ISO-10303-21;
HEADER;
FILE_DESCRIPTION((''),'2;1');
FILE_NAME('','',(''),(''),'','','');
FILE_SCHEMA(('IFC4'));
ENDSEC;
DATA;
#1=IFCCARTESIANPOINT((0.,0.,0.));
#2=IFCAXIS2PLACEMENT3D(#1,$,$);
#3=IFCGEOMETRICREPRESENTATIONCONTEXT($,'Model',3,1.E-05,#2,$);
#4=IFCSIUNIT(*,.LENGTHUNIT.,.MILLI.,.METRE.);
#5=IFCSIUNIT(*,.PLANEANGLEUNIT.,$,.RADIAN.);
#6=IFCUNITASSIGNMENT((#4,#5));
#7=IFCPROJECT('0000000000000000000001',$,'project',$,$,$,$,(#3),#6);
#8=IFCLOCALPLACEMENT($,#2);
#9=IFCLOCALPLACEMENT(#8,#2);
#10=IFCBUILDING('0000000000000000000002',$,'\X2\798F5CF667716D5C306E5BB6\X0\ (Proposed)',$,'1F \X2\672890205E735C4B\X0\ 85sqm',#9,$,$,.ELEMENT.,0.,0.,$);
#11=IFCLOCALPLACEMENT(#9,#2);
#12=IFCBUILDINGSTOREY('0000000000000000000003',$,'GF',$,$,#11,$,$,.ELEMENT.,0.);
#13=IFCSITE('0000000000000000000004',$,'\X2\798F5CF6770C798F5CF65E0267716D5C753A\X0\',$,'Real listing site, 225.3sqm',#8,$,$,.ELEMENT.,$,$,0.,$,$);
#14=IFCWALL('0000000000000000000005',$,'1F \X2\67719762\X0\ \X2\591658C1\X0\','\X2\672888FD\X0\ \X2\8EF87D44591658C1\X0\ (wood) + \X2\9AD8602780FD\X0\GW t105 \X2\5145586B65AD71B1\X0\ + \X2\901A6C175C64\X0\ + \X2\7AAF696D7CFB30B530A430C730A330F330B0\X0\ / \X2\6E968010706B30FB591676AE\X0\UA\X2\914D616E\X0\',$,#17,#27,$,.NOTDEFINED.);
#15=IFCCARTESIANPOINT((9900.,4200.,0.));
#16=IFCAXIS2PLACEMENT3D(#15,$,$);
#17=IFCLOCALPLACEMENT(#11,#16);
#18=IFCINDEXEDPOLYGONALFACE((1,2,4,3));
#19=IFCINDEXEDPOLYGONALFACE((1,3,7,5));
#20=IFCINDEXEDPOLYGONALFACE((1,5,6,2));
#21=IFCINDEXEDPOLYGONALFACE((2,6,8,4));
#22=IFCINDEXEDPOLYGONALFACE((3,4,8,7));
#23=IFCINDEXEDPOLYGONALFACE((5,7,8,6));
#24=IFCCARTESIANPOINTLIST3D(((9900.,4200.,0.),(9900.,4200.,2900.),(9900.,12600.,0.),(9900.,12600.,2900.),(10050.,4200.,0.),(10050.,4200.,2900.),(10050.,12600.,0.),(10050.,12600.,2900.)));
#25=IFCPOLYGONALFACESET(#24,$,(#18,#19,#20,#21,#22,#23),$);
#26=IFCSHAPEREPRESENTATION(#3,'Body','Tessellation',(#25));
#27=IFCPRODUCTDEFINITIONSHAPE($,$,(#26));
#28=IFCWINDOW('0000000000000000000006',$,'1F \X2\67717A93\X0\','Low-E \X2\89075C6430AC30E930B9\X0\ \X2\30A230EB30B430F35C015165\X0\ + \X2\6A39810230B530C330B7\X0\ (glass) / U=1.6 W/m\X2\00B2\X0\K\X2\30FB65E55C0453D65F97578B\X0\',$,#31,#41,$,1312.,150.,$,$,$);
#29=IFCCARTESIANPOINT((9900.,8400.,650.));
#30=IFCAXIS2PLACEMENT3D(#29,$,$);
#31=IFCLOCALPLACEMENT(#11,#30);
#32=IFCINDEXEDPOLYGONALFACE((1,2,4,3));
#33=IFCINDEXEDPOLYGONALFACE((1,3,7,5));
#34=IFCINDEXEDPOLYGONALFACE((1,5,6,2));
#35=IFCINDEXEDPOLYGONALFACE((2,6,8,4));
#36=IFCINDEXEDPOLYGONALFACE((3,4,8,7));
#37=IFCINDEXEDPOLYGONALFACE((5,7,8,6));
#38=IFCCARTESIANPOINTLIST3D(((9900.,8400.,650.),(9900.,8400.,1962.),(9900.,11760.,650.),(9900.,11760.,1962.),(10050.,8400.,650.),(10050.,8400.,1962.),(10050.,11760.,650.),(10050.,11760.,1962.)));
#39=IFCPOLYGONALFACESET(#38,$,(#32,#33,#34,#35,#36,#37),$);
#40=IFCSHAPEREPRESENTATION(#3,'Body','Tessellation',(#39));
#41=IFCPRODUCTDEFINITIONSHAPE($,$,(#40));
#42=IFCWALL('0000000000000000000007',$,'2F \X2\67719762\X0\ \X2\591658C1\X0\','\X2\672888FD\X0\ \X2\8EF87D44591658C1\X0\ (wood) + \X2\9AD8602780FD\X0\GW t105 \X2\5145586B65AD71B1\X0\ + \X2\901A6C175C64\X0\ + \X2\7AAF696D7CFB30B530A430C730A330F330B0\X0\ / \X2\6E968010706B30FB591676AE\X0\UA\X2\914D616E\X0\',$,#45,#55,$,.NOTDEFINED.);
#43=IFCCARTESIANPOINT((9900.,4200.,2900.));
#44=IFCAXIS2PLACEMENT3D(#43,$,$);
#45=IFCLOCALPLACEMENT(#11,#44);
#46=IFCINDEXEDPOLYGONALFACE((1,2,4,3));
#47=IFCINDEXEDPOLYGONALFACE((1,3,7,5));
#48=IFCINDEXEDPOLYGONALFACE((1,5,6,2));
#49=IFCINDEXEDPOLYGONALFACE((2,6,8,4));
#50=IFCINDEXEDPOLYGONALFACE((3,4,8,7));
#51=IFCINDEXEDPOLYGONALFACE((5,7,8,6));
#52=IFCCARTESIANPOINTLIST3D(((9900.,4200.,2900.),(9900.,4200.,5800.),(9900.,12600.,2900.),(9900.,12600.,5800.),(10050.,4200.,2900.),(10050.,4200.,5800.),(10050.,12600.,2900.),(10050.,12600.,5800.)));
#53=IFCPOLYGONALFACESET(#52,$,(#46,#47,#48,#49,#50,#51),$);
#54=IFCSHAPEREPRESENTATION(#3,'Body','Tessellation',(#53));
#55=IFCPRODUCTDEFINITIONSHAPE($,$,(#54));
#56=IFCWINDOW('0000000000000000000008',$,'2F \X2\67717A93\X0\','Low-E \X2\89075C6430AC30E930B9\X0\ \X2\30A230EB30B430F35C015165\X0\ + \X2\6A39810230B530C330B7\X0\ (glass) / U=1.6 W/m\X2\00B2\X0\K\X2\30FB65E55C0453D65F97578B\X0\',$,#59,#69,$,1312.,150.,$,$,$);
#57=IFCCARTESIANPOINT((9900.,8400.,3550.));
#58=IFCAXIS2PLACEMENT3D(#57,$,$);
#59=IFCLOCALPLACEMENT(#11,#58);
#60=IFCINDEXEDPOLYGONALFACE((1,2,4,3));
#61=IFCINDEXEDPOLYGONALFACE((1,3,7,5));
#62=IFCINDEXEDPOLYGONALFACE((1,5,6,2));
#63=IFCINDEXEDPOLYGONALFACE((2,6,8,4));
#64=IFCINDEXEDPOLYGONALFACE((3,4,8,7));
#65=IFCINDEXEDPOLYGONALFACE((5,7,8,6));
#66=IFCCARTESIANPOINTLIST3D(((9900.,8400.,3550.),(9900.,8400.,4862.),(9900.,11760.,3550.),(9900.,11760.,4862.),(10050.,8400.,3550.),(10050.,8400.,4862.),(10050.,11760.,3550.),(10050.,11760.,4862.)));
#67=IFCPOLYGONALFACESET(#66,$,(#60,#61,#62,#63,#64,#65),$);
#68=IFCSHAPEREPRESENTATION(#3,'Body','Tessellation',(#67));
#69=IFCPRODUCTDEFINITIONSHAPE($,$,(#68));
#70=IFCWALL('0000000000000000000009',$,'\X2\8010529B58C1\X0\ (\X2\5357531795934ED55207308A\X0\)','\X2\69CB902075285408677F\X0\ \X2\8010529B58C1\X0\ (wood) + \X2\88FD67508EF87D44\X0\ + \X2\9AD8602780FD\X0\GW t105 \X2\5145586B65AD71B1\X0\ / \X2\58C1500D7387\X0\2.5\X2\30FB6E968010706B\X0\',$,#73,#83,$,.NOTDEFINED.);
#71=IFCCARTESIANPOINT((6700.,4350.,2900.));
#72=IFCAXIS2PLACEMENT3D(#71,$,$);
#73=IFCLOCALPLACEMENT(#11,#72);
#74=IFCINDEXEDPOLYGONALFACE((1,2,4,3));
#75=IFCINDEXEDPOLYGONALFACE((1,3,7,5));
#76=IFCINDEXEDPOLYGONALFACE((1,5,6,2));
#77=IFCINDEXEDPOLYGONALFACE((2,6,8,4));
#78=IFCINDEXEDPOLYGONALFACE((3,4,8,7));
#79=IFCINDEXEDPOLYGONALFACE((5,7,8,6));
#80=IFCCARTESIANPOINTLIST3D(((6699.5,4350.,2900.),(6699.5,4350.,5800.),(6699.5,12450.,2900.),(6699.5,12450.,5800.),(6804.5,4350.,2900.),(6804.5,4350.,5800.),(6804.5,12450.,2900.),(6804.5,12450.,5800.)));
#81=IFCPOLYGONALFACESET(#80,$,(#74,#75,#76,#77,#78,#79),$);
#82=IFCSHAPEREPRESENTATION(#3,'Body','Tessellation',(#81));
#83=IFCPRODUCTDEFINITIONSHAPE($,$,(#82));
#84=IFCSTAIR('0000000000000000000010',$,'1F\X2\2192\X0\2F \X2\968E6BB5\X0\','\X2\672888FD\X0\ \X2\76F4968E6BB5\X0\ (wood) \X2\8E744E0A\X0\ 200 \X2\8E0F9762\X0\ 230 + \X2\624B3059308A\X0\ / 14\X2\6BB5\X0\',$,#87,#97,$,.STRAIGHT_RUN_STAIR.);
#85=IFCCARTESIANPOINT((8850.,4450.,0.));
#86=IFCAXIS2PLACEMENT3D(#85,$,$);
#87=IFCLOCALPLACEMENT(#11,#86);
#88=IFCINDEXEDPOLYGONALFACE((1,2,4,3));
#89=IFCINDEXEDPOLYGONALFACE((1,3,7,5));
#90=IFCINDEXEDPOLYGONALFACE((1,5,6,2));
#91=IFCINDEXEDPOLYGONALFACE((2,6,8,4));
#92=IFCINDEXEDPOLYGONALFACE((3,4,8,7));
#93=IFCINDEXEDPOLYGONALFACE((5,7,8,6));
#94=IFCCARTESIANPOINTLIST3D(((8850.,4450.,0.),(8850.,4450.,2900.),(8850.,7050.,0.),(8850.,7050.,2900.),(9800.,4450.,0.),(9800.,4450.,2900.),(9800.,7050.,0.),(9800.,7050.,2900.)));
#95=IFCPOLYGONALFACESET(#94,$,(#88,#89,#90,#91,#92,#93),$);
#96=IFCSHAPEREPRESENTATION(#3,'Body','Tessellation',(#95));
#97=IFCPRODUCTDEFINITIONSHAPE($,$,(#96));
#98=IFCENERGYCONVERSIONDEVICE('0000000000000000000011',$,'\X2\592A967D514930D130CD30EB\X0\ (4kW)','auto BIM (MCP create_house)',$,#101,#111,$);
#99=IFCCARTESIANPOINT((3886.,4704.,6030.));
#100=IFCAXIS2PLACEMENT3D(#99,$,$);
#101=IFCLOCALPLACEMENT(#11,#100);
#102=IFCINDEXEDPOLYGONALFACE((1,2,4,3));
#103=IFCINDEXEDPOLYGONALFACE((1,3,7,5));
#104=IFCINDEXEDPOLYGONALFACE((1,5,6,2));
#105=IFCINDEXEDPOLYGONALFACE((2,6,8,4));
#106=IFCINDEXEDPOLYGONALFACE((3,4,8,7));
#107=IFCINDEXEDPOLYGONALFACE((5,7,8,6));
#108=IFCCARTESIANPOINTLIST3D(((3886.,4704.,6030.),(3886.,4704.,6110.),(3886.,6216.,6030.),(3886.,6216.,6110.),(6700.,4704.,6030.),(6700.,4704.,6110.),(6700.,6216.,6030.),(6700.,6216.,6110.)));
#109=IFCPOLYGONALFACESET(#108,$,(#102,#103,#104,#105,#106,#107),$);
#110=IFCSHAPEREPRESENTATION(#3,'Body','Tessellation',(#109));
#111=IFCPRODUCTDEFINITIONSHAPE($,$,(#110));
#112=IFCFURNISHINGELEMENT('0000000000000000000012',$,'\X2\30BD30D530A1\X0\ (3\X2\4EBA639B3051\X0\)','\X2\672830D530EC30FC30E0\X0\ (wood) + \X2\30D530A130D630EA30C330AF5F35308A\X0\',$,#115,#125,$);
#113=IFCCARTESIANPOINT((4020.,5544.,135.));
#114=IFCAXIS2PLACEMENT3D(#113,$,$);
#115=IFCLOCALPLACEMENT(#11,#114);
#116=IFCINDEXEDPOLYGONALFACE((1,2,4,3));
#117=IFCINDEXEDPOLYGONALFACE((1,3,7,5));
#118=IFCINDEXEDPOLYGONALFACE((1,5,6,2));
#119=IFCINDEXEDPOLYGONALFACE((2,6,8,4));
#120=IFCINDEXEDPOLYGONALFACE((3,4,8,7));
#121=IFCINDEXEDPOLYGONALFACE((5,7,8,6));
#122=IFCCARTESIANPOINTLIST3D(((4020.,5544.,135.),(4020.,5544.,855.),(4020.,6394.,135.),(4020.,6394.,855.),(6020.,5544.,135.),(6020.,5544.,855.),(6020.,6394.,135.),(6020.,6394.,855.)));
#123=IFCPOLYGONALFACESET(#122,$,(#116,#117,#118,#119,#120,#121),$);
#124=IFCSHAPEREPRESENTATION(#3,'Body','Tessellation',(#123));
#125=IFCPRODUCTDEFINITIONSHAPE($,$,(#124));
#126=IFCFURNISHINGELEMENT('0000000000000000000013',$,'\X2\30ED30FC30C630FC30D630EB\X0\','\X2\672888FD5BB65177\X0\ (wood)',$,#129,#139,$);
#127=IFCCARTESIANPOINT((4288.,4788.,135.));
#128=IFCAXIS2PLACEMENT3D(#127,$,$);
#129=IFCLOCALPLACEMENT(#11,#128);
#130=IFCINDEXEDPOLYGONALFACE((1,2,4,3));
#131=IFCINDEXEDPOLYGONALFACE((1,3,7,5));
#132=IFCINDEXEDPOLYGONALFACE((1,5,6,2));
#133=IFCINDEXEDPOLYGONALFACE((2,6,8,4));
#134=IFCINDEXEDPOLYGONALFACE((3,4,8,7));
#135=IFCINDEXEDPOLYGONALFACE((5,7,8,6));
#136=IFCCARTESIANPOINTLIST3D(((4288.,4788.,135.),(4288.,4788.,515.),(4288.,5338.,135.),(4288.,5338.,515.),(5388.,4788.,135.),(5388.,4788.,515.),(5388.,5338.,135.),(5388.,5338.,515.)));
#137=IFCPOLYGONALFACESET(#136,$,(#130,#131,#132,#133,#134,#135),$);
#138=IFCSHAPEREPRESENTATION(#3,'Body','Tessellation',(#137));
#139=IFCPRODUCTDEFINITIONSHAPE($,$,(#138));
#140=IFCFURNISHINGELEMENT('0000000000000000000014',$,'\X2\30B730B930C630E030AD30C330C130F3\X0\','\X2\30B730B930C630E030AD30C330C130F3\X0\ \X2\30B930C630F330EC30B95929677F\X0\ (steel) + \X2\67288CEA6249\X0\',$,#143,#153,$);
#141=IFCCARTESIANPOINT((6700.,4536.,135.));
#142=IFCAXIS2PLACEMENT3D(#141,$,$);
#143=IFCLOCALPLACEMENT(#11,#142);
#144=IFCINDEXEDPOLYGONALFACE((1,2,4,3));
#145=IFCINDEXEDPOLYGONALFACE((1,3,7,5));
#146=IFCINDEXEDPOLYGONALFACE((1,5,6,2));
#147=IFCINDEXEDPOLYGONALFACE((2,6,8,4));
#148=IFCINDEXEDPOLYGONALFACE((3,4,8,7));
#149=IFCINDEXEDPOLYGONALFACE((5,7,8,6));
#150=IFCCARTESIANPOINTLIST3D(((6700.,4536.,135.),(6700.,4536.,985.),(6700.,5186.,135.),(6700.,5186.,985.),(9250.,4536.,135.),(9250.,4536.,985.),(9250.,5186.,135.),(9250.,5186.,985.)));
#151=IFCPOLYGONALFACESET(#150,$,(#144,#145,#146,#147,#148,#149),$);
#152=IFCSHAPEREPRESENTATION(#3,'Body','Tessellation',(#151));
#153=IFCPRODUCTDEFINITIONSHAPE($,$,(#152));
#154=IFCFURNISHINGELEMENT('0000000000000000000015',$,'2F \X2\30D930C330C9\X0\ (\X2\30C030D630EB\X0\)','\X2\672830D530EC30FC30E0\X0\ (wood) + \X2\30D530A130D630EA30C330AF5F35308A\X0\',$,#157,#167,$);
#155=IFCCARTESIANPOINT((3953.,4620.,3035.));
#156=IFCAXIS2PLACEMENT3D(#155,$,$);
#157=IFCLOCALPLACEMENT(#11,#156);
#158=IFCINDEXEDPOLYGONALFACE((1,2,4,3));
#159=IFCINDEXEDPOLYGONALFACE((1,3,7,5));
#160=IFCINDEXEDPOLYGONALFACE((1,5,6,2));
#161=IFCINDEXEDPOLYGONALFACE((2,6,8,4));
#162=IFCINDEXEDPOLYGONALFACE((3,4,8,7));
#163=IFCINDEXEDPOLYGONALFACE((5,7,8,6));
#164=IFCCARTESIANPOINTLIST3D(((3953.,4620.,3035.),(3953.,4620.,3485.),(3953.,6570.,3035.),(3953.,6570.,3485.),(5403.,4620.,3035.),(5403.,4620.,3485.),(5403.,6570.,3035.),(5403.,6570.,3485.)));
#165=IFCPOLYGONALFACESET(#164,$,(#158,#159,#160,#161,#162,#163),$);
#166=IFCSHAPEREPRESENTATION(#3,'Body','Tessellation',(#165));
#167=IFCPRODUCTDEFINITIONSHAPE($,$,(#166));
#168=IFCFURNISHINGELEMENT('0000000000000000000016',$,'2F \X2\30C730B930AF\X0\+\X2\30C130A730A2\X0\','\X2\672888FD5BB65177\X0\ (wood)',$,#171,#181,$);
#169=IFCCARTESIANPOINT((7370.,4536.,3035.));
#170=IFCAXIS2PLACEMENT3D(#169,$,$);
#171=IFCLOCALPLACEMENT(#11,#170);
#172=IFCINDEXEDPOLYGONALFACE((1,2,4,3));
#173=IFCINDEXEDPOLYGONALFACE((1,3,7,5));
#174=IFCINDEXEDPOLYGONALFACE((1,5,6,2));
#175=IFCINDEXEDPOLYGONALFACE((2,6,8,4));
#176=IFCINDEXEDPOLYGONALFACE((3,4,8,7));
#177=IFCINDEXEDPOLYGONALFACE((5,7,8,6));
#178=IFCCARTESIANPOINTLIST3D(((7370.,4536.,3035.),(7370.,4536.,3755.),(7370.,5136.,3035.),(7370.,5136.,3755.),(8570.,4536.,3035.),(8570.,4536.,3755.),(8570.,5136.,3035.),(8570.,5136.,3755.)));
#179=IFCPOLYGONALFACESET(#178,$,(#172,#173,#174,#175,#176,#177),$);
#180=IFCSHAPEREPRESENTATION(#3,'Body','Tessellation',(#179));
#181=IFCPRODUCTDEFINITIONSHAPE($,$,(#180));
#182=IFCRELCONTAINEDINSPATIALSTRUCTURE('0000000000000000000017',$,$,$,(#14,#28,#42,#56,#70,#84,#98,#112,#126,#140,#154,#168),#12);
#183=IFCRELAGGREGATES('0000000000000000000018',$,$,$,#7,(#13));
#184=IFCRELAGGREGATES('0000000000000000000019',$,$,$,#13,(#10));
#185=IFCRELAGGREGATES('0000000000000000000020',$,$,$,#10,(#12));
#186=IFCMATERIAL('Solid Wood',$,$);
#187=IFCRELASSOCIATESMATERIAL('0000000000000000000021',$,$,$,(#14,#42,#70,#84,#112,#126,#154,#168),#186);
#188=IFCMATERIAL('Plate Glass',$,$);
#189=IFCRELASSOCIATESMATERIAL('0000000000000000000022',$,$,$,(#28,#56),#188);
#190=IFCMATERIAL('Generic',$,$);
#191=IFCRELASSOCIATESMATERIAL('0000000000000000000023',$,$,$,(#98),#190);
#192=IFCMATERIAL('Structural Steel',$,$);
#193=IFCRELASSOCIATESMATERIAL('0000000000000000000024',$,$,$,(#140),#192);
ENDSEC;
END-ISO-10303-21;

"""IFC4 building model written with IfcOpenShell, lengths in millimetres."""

from ifc_helpers import new_model, si_unit, frame, frame_2d, origin, place, context, project, spatial, rectangle, extrude, material, element, fill, save


model = new_model("IFC4")

# Units and contexts
model_context = context("Model", 3, precision=1e-05, world=origin())
ifc_project = project(units=[si_unit("LENGTHUNIT", "METRE", prefix="MILLI"), si_unit("PLANEANGLEUNIT", "RADIAN")], contexts=[model_context])

# Site, building, storey
site_placement = place(None, origin())
site = spatial("IfcSite", under=ifc_project, at=site_placement, Name="福島県福島市東浜町", ObjectType="Real listing site, 225.3sqm", CompositionType="ELEMENT", RefElevation=0.0)
building_placement = place(site_placement, origin())
building = spatial("IfcBuilding", under=site, at=building_placement, Name="福島東浜の家 (Proposed)", ObjectType="1F 木造平屋 85sqm", CompositionType="ELEMENT", ElevationOfRefHeight=0.0, ElevationOfTerrain=0.0)
storey_placement = place(building_placement, origin())
storey = spatial("IfcBuildingStorey", under=building, at=storey_placement, Name="GF", CompositionType="ELEMENT", Elevation=0.0)

# Wall, opening, window
ifc_material_1 = material(Name="Solid Wood")
wall_1_placement = place(storey_placement, frame((9900.0, 4200.0, 0.0)))
wall_1 = element("IfcWall", 1, at=wall_1_placement, inside=storey, material=ifc_material_1, Name="1F 東面 外壁", Description="木製 軸組外壁 (wood) + 高性能GW t105 充填断熱 + 通気層 + 窯業系サイディング / 準耐火・外皮UA配慮", PredefinedType="NOTDEFINED", context=model_context, shape_type="SweptSolid", body=[
    extrude(rectangle(XDim=150.0, YDim=8400.0, at=frame_2d((75.0, 4200.0))), frame((9900.0, 4200.0, 0.0)), (0.0, 0.0, 1.0), 2900.0),
])
opening_1_placement = place(storey_placement, frame((9900.0, 8400.0, 650.0)))
opening_1 = element("IfcOpeningElement", 2, at=opening_1_placement, cuts=wall_1, PredefinedType="NOTDEFINED", context=model_context, shape_type="SweptSolid", body=[
    extrude(rectangle(XDim=150.0, YDim=3360.0, at=frame_2d((75.0, 1680.0))), frame((9900.0, 8400.0, 650.0)), (0.0, 0.0, 1.0), 1312.0),
])
ifc_material_2 = material(Name="Plate Glass")
window_1_placement = place(storey_placement, frame((9900.0, 8400.0, 650.0)))
window_1 = element("IfcWindow", 3, at=window_1_placement, inside=storey, material=ifc_material_2, Name="1F 東窓", Description="Low-E 複層ガラス アルゴン封入 + 樹脂サッシ (glass) / U=1.6 W/m²K・日射取得型", OverallHeight=1312.0, OverallWidth=150.0, context=model_context, shape_type="SweptSolid", body=[
    extrude(rectangle(XDim=150.0, YDim=3360.0, at=frame_2d((75.0, 1680.0))), frame((9900.0, 8400.0, 650.0)), (0.0, 0.0, 1.0), 1312.0),
])
fill(opening_1, window_1)

# Wall, opening, window
wall_2_placement = place(storey_placement, frame((9900.0, 4200.0, 2900.0)))
wall_2 = element("IfcWall", 4, at=wall_2_placement, inside=storey, material=ifc_material_1, Name="2F 東面 外壁", Description="木製 軸組外壁 (wood) + 高性能GW t105 充填断熱 + 通気層 + 窯業系サイディング / 準耐火・外皮UA配慮", PredefinedType="NOTDEFINED", context=model_context, shape_type="SweptSolid", body=[
    extrude(rectangle(XDim=150.0, YDim=8400.0, at=frame_2d((75.0, 4200.0))), frame((9900.0, 4200.0, 2900.0)), (0.0, 0.0, 1.0), 2900.0),
])
opening_2_placement = place(storey_placement, frame((9900.0, 8400.0, 3550.0)))
opening_2 = element("IfcOpeningElement", 5, at=opening_2_placement, cuts=wall_2, PredefinedType="NOTDEFINED", context=model_context, shape_type="SweptSolid", body=[
    extrude(rectangle(XDim=150.0, YDim=3360.0, at=frame_2d((75.0, 1680.0))), frame((9900.0, 8400.0, 3550.0)), (0.0, 0.0, 1.0), 1312.0),
])
window_2_placement = place(storey_placement, frame((9900.0, 8400.0, 3550.0)))
window_2 = element("IfcWindow", 6, at=window_2_placement, inside=storey, material=ifc_material_2, Name="2F 東窓", Description="Low-E 複層ガラス アルゴン封入 + 樹脂サッシ (glass) / U=1.6 W/m²K・日射取得型", OverallHeight=1312.0, OverallWidth=150.0, context=model_context, shape_type="SweptSolid", body=[
    extrude(rectangle(XDim=150.0, YDim=3360.0, at=frame_2d((75.0, 1680.0))), frame((9900.0, 8400.0, 3550.0)), (0.0, 0.0, 1.0), 1312.0),
])
fill(opening_2, window_2)

# Wall
wall_3_placement = place(storey_placement, frame((6700.0, 4350.0, 2900.0)))
element("IfcWall", 7, at=wall_3_placement, inside=storey, material=ifc_material_1, Name="耐力壁 (南北間仕切り)", Description="構造用合板 耐力壁 (wood) + 製材軸組 + 高性能GW t105 充填断熱 / 壁倍率2.5・準耐火", PredefinedType="NOTDEFINED", context=model_context, shape_type="SweptSolid", body=[
    extrude(rectangle(XDim=105.0, YDim=8100.0, at=frame_2d((52.0, 4050.0))), frame((6700.0, 4350.0, 2900.0)), (0.0, 0.0, 1.0), 2900.0),
])

# Stair
stair_placement = place(storey_placement, frame((8850.0, 4450.0, 0.0)))
element("IfcStair", 8, at=stair_placement, inside=storey, material=ifc_material_1, Name="1F→2F 階段", Description="木製 直階段 (wood) 蹴上 200 踏面 230 + 手すり / 14段", PredefinedType="STRAIGHT_RUN_STAIR", context=model_context, shape_type="SweptSolid", body=[
    extrude(rectangle(XDim=950.0, YDim=2600.0, at=frame_2d((475.0, 1300.0))), frame((8850.0, 4450.0, 0.0)), (0.0, 0.0, 1.0), 2900.0),
])

# Energy conversion device
ifc_material_3 = material(Name="Generic")
energy_conversion_device_placement = place(storey_placement, frame((3886.0, 4704.0, 6030.0)))
element("IfcEnergyConversionDevice", 9, at=energy_conversion_device_placement, inside=storey, material=ifc_material_3, Name="太陽光パネル (4kW)", Description="auto BIM (MCP create_house)", context=model_context, shape_type="SweptSolid", body=[
    extrude(rectangle(XDim=2814.0, YDim=1512.0, at=frame_2d((1407.0, 756.0))), frame((3886.0, 4704.0, 6030.0)), (0.0, 0.0, 1.0), 80.0),
])

# Furnishing elements
furnishing_1_placement = place(storey_placement, frame((4020.0, 5544.0, 135.0)))
element("IfcFurnishingElement", 10, at=furnishing_1_placement, inside=storey, material=ifc_material_1, Name="ソファ (3人掛け)", Description="木フレーム (wood) + ファブリック張り", context=model_context, shape_type="SweptSolid", body=[
    extrude(rectangle(XDim=2000.0, YDim=850.0, at=frame_2d((1000.0, 425.0))), frame((4020.0, 5544.0, 135.0)), (0.0, 0.0, 1.0), 720.0),
])
furnishing_2_placement = place(storey_placement, frame((4288.0, 4788.0, 135.0)))
element("IfcFurnishingElement", 11, at=furnishing_2_placement, inside=storey, material=ifc_material_1, Name="ローテーブル", Description="木製家具 (wood)", context=model_context, shape_type="SweptSolid", body=[
    extrude(rectangle(XDim=1100.0, YDim=550.0, at=frame_2d((550.0, 275.0))), frame((4288.0, 4788.0, 135.0)), (0.0, 0.0, 1.0), 380.0),
])
ifc_material_4 = material(Name="Structural Steel")
furnishing_3_placement = place(storey_placement, frame((6700.0, 4536.0, 135.0)))
element("IfcFurnishingElement", 12, at=furnishing_3_placement, inside=storey, material=ifc_material_4, Name="システムキッチン", Description="システムキッチン ステンレス天板 (steel) + 木質扉", context=model_context, shape_type="SweptSolid", body=[
    extrude(rectangle(XDim=2550.0, YDim=650.0, at=frame_2d((1275.0, 325.0))), frame((6700.0, 4536.0, 135.0)), (0.0, 0.0, 1.0), 850.0),
])
furnishing_4_placement = place(storey_placement, frame((3953.0, 4620.0, 3035.0)))
element("IfcFurnishingElement", 13, at=furnishing_4_placement, inside=storey, material=ifc_material_1, Name="2F ベッド (ダブル)", Description="木フレーム (wood) + ファブリック張り", context=model_context, shape_type="SweptSolid", body=[
    extrude(rectangle(XDim=1450.0, YDim=1950.0, at=frame_2d((725.0, 975.0))), frame((3953.0, 4620.0, 3035.0)), (0.0, 0.0, 1.0), 450.0),
])
furnishing_5_placement = place(storey_placement, frame((7370.0, 4536.0, 3035.0)))
element("IfcFurnishingElement", 14, at=furnishing_5_placement, inside=storey, material=ifc_material_1, Name="2F デスク+チェア", Description="木製家具 (wood)", context=model_context, shape_type="SweptSolid", body=[
    extrude(rectangle(XDim=1200.0, YDim=600.0, at=frame_2d((600.0, 300.0))), frame((7370.0, 4536.0, 3035.0)), (0.0, 0.0, 1.0), 720.0),
])

save(model, "model.ifc")
